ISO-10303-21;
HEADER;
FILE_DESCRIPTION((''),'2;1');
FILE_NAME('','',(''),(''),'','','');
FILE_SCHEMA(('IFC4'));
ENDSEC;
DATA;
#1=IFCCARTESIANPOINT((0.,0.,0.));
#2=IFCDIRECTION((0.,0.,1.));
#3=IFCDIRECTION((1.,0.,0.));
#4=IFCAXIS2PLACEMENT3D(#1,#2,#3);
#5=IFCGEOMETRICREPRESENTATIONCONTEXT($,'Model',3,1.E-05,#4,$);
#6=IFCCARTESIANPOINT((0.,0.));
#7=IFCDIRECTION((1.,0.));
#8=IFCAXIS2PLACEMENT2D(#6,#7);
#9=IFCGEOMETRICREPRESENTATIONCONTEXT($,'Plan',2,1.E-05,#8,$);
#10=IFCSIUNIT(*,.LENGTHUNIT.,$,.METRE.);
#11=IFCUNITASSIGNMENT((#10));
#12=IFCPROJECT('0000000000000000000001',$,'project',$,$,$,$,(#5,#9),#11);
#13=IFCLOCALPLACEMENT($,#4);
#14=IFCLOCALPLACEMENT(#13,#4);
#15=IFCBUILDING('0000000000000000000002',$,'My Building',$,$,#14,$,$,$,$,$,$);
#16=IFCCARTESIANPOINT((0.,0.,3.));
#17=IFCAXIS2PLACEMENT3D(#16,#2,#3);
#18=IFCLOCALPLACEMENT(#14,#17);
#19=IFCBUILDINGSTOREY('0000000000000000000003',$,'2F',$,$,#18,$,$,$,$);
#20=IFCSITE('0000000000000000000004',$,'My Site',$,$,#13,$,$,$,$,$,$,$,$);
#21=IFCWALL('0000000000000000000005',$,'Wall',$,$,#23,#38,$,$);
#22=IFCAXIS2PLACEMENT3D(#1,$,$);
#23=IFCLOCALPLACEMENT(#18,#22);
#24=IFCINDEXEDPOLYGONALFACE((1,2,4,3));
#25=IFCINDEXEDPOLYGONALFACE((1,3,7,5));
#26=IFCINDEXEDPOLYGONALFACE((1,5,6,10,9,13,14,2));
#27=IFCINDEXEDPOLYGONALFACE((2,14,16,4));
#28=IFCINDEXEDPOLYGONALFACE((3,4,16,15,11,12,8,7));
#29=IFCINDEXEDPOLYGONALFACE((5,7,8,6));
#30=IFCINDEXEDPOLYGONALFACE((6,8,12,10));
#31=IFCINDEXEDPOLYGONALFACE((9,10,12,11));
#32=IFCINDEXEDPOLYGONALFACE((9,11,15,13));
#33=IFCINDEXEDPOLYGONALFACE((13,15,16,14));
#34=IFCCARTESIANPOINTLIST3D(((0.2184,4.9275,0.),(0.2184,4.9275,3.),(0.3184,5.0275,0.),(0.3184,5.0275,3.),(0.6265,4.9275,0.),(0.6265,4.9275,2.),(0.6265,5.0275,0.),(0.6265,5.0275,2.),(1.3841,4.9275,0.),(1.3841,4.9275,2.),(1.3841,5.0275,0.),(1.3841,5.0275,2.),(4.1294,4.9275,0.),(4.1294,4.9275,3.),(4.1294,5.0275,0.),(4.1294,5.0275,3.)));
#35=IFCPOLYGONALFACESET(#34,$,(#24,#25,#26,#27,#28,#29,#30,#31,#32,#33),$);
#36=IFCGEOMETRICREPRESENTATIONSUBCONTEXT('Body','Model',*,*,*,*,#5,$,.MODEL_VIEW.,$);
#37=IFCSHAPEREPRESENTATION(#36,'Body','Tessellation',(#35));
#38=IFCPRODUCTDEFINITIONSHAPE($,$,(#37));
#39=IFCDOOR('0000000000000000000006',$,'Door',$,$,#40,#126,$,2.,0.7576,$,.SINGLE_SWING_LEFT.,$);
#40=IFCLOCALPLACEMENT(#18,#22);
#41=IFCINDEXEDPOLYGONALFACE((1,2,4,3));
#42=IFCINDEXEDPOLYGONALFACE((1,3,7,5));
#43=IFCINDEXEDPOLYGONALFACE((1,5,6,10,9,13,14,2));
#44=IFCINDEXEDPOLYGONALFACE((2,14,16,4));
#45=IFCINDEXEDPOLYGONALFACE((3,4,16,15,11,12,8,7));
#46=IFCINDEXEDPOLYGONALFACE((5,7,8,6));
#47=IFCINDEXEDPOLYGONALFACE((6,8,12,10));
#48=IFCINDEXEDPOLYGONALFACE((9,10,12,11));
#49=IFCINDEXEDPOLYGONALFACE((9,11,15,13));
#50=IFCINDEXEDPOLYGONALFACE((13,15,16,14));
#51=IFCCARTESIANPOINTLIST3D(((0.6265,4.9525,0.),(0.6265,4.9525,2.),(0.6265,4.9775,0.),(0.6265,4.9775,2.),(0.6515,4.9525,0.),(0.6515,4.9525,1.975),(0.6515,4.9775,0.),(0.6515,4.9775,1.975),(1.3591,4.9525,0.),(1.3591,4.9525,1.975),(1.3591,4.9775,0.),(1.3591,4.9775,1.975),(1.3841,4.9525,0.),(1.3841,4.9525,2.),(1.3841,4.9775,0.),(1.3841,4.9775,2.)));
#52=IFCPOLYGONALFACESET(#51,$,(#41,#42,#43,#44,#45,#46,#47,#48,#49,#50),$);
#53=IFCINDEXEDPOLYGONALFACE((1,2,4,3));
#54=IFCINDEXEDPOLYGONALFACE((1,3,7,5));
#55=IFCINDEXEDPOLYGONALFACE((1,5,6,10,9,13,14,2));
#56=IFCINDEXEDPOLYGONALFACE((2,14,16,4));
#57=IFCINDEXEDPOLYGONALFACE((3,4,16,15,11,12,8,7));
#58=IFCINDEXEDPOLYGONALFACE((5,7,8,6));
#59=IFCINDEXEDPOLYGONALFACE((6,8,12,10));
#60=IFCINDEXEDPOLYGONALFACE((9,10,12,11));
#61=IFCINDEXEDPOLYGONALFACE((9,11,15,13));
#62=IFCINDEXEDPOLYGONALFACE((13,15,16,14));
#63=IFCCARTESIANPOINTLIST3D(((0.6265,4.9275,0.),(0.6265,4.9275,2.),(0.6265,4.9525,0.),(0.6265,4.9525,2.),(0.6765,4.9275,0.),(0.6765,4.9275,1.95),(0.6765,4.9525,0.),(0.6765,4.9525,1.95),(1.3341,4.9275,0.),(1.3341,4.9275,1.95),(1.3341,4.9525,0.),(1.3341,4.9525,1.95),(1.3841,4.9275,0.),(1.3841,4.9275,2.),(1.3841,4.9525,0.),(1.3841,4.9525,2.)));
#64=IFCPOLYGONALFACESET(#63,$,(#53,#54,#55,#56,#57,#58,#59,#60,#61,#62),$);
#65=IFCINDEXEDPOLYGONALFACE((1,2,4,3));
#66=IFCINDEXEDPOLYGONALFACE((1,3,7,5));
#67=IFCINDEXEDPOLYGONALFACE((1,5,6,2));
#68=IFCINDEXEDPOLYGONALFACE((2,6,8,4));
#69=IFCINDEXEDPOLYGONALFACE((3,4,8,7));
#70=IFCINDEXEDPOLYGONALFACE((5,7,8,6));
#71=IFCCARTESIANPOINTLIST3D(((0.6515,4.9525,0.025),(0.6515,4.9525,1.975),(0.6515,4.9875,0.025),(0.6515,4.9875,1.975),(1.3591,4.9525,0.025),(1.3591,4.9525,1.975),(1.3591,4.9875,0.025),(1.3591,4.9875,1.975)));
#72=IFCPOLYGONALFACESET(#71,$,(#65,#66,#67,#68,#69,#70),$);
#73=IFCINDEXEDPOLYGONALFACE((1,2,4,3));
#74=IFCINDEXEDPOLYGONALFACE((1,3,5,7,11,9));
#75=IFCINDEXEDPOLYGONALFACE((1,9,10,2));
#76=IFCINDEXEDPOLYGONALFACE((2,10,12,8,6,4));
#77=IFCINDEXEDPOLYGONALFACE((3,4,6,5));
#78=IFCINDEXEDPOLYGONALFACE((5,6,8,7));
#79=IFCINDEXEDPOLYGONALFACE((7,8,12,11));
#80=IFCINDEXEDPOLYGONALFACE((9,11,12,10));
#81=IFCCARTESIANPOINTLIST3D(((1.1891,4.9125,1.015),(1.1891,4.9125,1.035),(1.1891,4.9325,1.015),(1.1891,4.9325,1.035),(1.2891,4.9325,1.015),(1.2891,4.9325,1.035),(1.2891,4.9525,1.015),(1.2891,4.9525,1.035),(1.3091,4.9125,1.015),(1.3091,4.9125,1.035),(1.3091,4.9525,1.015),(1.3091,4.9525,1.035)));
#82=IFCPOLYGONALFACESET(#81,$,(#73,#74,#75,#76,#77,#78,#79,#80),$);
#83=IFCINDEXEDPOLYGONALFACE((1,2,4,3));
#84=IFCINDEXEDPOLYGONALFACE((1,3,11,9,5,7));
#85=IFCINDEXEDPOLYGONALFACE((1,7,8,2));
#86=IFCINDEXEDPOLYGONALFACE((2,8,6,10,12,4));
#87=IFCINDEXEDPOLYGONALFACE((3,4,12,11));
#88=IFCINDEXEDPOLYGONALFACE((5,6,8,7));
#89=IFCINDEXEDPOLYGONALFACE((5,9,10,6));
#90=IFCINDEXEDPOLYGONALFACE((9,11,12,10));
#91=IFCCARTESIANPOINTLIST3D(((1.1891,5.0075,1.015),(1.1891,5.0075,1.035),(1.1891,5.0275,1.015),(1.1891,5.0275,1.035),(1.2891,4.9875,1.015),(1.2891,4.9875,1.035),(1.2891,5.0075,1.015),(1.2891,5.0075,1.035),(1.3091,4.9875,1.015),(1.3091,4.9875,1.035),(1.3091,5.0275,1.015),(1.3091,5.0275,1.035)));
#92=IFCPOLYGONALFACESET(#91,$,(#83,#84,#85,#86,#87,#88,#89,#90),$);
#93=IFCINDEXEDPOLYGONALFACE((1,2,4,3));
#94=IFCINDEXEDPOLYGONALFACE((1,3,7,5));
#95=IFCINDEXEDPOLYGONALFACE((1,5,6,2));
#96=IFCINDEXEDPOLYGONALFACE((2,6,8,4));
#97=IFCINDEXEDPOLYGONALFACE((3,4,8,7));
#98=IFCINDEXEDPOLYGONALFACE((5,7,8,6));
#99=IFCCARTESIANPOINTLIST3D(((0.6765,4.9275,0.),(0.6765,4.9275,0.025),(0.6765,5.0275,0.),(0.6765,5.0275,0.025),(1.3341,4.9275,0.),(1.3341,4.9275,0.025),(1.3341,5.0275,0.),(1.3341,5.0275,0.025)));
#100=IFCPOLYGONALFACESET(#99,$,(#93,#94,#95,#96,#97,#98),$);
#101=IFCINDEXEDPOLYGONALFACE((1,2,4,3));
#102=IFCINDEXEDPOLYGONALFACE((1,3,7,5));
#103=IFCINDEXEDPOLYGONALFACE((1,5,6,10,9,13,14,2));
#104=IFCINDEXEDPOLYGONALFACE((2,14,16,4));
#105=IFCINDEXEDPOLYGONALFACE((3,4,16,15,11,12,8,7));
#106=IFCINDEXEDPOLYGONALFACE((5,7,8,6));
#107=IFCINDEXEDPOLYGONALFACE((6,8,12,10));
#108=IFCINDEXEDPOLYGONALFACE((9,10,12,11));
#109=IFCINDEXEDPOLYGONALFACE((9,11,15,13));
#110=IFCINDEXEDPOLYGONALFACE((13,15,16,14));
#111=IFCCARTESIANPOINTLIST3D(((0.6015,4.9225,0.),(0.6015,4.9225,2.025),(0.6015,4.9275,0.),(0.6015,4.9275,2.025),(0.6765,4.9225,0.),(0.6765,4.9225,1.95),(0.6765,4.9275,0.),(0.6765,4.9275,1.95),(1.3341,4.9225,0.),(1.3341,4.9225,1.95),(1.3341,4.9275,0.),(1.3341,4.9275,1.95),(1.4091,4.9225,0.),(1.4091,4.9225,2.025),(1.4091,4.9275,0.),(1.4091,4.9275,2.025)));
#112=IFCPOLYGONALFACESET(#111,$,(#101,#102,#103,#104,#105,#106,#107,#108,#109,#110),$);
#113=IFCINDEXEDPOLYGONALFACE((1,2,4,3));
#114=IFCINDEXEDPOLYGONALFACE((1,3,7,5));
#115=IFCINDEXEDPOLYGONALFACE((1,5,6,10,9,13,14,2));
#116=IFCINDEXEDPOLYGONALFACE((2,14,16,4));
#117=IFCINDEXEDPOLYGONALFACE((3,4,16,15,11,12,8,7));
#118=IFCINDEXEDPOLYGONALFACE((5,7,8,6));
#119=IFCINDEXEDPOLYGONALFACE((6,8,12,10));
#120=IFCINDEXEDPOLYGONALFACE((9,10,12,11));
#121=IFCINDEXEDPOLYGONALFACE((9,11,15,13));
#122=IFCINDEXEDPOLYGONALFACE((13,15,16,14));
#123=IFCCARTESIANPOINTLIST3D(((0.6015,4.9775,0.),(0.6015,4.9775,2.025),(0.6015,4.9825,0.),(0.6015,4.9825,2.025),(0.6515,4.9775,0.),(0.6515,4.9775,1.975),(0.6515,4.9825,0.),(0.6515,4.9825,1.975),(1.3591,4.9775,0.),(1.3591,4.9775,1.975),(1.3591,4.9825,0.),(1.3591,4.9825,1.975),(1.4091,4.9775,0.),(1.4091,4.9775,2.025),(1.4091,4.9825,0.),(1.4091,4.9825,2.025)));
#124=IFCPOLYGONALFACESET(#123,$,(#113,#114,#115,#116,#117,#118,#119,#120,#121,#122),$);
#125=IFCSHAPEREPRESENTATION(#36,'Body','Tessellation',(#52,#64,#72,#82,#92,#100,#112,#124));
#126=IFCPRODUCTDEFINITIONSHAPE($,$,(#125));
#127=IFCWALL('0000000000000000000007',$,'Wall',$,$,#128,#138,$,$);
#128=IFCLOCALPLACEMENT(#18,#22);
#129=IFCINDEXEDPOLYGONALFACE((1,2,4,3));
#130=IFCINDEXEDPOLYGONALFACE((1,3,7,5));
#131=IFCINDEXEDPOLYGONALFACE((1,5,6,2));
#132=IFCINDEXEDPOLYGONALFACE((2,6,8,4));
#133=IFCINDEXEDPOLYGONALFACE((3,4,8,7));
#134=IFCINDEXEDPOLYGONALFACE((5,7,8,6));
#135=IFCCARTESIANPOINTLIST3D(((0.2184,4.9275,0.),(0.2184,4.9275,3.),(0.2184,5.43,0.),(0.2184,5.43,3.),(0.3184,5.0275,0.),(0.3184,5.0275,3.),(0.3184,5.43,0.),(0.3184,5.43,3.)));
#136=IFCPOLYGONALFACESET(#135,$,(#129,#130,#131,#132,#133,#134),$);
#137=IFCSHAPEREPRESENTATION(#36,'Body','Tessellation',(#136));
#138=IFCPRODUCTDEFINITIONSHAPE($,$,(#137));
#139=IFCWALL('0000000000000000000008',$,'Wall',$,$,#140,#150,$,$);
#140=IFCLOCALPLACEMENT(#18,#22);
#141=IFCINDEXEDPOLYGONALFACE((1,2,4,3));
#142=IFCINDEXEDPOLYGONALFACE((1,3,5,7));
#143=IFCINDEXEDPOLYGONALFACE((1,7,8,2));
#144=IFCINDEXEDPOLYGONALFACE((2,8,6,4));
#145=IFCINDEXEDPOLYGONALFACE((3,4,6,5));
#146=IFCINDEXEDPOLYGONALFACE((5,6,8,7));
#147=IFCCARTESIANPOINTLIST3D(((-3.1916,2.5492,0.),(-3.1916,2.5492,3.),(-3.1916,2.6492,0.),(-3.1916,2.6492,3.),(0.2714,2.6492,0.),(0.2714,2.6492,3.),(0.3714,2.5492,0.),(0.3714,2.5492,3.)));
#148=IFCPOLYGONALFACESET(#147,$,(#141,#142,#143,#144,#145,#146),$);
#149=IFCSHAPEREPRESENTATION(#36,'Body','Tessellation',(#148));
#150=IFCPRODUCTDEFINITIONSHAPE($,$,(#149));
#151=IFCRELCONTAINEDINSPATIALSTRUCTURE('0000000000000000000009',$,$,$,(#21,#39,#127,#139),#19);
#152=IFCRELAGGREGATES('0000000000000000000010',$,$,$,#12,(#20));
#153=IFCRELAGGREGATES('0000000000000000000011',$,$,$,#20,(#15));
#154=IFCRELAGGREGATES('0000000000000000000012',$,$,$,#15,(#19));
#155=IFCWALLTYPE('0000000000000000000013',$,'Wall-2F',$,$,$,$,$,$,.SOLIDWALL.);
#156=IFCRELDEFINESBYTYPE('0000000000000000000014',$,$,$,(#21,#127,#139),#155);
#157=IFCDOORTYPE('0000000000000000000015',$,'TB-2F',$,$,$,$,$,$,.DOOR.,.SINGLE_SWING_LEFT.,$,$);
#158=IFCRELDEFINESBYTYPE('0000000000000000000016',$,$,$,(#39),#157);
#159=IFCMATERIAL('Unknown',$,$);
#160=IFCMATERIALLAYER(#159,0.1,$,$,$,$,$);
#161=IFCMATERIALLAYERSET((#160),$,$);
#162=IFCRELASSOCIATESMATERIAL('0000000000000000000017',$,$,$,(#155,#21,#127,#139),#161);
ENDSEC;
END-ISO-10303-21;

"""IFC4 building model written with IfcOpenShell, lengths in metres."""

from ifc_helpers import new_model, entity, si_unit, frame, origin_with_axes, origin_2d_with_axis, place, context, subcontext, project, spatial, line, indexed_curve, outline, extrude, shape, source, transform, mapped, material, layer, layer_set, layer_usage, type_object, type_shapes, element, fill, save


model = new_model("IFC4")

# Units and contexts
model_context = context("Model", 3, precision=1e-05, world=origin_with_axes())
plan_context = context("Plan", 2, precision=1e-05, world=origin_2d_with_axis())
body_context_1 = subcontext(model_context, "Body", "Model", "MODEL_VIEW")
body_context_2 = subcontext(plan_context, "Body", "Plan", "PLAN_VIEW")
ifc_project = project(units=[si_unit("LENGTHUNIT", "METRE")], contexts=[model_context, plan_context])

# Site, building, storey
site_placement = place(None, origin_with_axes())
site = spatial("IfcSite", under=ifc_project, at=site_placement, Name="My Site")
building_placement = place(site_placement, origin_with_axes())
building = spatial("IfcBuilding", under=site, at=building_placement, Name="My Building")
storey_placement = place(building_placement, frame((0.0, 0.0, 3.0), z_axis=(0.0, 0.0, 1.0), x_axis=(1.0, 0.0, 0.0)))
storey = spatial("IfcBuildingStorey", under=building, at=storey_placement, Name="2F")

# Shared definitions
ifc_material = material(Name="Unknown")
ifc_layer = layer(ifc_material, 0.1)
ifc_layer_set = layer_set([ifc_layer])
wall_type = type_object("IfcWallType", Name="Wall-2F", PredefinedType="SOLIDWALL", material=ifc_layer_set)

# Wall, opening, door
ifc_layer_usage_1 = layer_usage(ifc_layer_set, "AXIS2", "POSITIVE", 0.0)
wall_1_placement = place(storey_placement, frame((4.2294, 5.0275, 0.0), z_axis=(0.0, 0.0, 1.0), x_axis=(-1.0, 0.0, 0.0)))
wall_1 = element("IfcWall", 1, at=wall_1_placement, inside=storey, type_object=wall_type, material=ifc_layer_usage_1, Name="Wall", context=body_context_1, shape_type="SweptSolid", body=[
    extrude(outline(indexed_curve([(0.1, 0.0), (0.1, 0.1), (4.0111, 0.1), (3.9111, 0.0)], segments=[line(1, 2, 3, 4, 1)])), origin_with_axes(), (0.0, 0.0, 1.0), 3.0),
])
shared_shape_1 = source(origin_with_axes(), body_context_1, "Body", "SweptSolid", [
    extrude(outline(indexed_curve([(0.0, 0.0), (0.7576, 0.0), (0.7576, 2.0), (0.0, 2.0)], segments=[line(1, 2, 3, 4, 1)])), frame((0.0, -0.6, 0.0), z_axis=(0.0, -1.0, 0.0), x_axis=(1.0, 0.0, 0.0)), (0.0, 0.0, -1.0), 1.2),
])
opening_1_placement = place(wall_1_placement, frame((3.6029, 0.1, 0.0), z_axis=(0.0, 0.0, 1.0), x_axis=(-1.0, 0.0, 0.0)))
opening_1 = element("IfcOpeningElement", 2, at=opening_1_placement, cuts=wall_1, PredefinedType="OPENING", context=body_context_1, shape_type="MappedRepresentation", body=[
    mapped(shared_shape_1, transform((0.0, 0.0, 0.0), x_axis=(1.0, 0.0, 0.0), y_axis=(0.0, 1.0, 0.0), z_axis=(0.0, 0.0, 1.0), scale=1.0)),
])
door_type_1 = type_object("IfcDoorType", Name="TB-2F", OperationType="SINGLE_SWING_LEFT", PredefinedType="DOOR")
shared_shape_2 = source(origin_with_axes(), body_context_1, "Body", "SweptSolid", [
    extrude(outline(indexed_curve([(0.0, 0.0), (0.0, 2.0), (0.7576, 2.0), (0.7576, 0.0), (0.7326, 0.0), (0.7326, 1.975), (0.025, 1.975), (0.025, 0.0)], segments=[line(1, 2, 3, 4, 5, 6, 7, 8, 1)])), frame((0.0, 0.025, 0.0), z_axis=(0.0, -1.0, 0.0), x_axis=(1.0, 0.0, 0.0)), (0.0, 0.0, -1.0), 0.025),
    extrude(outline(indexed_curve([(0.0, 0.0), (0.0, 2.0), (0.7576, 2.0), (0.7576, 0.0), (0.7076, 0.0), (0.7076, 1.95), (0.05, 1.95), (0.05, 0.0)], segments=[line(1, 2, 3, 4, 5, 6, 7, 8, 1)])), frame((0.0, 0.0, 0.0), z_axis=(0.0, -1.0, 0.0), x_axis=(1.0, 0.0, 0.0)), (0.0, 0.0, -1.0), 0.025),
    extrude(outline(indexed_curve([(0.0, 0.0), (0.7076, 0.0), (0.7076, 0.035), (0.0, 0.035)], segments=[line(1, 2, 3, 4, 1)])), frame((0.025, 0.025, 0.025), z_axis=(0.0, 0.0, 1.0), x_axis=(1.0, 0.0, 0.0)), (0.0, 0.0, 1.0), 1.95),
    extrude(outline(indexed_curve([(0.0, 0.0), (0.0, -0.04), (-0.12, -0.04), (-0.12, -0.02), (-0.02, -0.02), (-0.02, 0.0)], segments=[line(1, 2, 3, 4, 5, 6, 1)])), frame((0.6826, 0.025, 1.015), z_axis=(0.0, 0.0, 1.0), x_axis=(1.0, 0.0, 0.0)), (0.0, 0.0, 1.0), 0.02),
    extrude(outline(indexed_curve([(0.0, 0.0), (0.0, 0.04), (-0.12, 0.04), (-0.12, 0.02), (-0.02, 0.02), (-0.02, 0.0)], segments=[line(1, 2, 3, 4, 5, 6, 1)])), frame((0.6826, 0.06, 1.015), z_axis=(0.0, 0.0, 1.0), x_axis=(1.0, 0.0, 0.0)), (0.0, 0.0, 1.0), 0.02),
    extrude(outline(indexed_curve([(0.0, 0.0), (0.6576, 0.0), (0.6576, 0.1), (0.0, 0.1)], segments=[line(1, 2, 3, 4, 1)])), frame((0.05, 0.0, 0.0), z_axis=(0.0, 0.0, 1.0), x_axis=(1.0, 0.0, 0.0)), (0.0, 0.0, 1.0), 0.025),
    extrude(outline(indexed_curve([(0.0, 0.0), (0.0, 2.025), (0.8076, 2.025), (0.8076, 0.0), (0.7326, 0.0), (0.7326, 1.95), (0.075, 1.95), (0.075, 0.0)], segments=[line(1, 2, 3, 4, 5, 6, 7, 8, 1)])), frame((-0.025, -0.005, 0.0), z_axis=(0.0, -1.0, 0.0), x_axis=(1.0, 0.0, 0.0)), (0.0, 0.0, -1.0), 0.005),
    extrude(outline(indexed_curve([(0.0, 0.0), (0.0, 2.025), (0.8076, 2.025), (0.8076, 0.0), (0.7576, 0.0), (0.7576, 1.975), (0.05, 1.975), (0.05, 0.0)], segments=[line(1, 2, 3, 4, 5, 6, 7, 8, 1)])), frame((-0.025, 0.05, 0.0), z_axis=(0.0, -1.0, 0.0), x_axis=(1.0, 0.0, 0.0)), (0.0, 0.0, -1.0), 0.005),
])
shared_shape_3 = source(origin_with_axes(), body_context_2, "Body", "Curve2D", [
    entity("IfcIndexedPolyCurve", entity("IfcCartesianPointList2D", [[0.0, 0.0], [0.0, 0.05], [0.025, 0.05], [0.025, 0.025], [0.05, 0.025], [0.05, 0.0]]), [entity("IfcLineIndex", [1, 2, 3, 4, 5, 6, 1])]),
    entity("IfcIndexedPolyCurve", entity("IfcCartesianPointList2D", [[0.7576, 0.0], [0.7576, 0.05], [0.7326, 0.05], [0.7326, 0.025], [0.7076, 0.025], [0.7076, 0.0]]), [entity("IfcLineIndex", [1, 2, 3, 4, 5, 6, 1])]),
    entity("IfcTrimmedCurve", entity("IfcEllipse", entity("IfcAxis2Placement2D", entity("IfcCartesianPoint", [0.06, 0.05]), entity("IfcDirection", [1.0, 0.0])), 0.6726, 0.7076), [entity("IfcCartesianPoint", [0.7326, 0.05])], [entity("IfcCartesianPoint", [0.06, 0.7576])], True, "CARTESIAN"),
    entity("IfcIndexedPolyCurve", entity("IfcCartesianPointList2D", [[0.025, 0.05], [0.06, 0.05], [0.06, 0.7576], [0.025, 0.7576]]), [entity("IfcLineIndex", [1, 2, 3, 4, 1])]),
])
type_shapes(door_type_1, [shared_shape_2, shared_shape_3])
door_1_placement = place(opening_1_placement, frame((0.0, 0.0, 0.0), z_axis=(0.0, 0.0, 1.0), x_axis=(1.0, 0.0, 0.0)))
door_1 = element("IfcDoor", 3, at=door_1_placement, inside=storey, type_object=door_type_1, Name="Door", OperationType="SINGLE_SWING_LEFT", OverallHeight=2.0, OverallWidth=0.7576, shapes=[
    shape(body_context_1, "Body", "MappedRepresentation", [mapped(shared_shape_2, transform((0.0, 0.0, 0.0), x_axis=(1.0, 0.0, 0.0), y_axis=(0.0, 1.0, 0.0), z_axis=(0.0, 0.0, 1.0), scale=1.0))]),
    shape(body_context_2, "Body", "MappedRepresentation", [mapped(shared_shape_3, transform((0.0, 0.0, 0.0), x_axis=(1.0, 0.0, 0.0), y_axis=(0.0, 1.0, 0.0), z_axis=(0.0, 0.0, 1.0), scale=1.0))]),
])
fill(opening_1, door_1)

# Walls
ifc_layer_usage_2 = layer_usage(ifc_layer_set, "AXIS2", "NEGATIVE", 0.0)
wall_2_placement = place(storey_placement, frame((0.3184, 5.43, 0.0), z_axis=(0.0, 0.0, 1.0), x_axis=(0.0, -1.0, 0.0)))
element("IfcWall", 4, at=wall_2_placement, inside=storey, type_object=wall_type, material=ifc_layer_usage_2, Name="Wall", context=body_context_1, shape_type="SweptSolid", body=[
    extrude(outline(indexed_curve([(0.0, -0.1), (0.0, 0.0), (0.4025, 0.0), (0.5025, -0.1)], segments=[line(1, 2, 3, 4, 1)])), origin_with_axes(), (0.0, 0.0, 1.0), 3.0),
])
ifc_layer_usage_3 = layer_usage(ifc_layer_set, "AXIS2", "POSITIVE", 0.0)
wall_3_placement = place(storey_placement, frame((-3.1916, 2.5492, 0.0), z_axis=(0.0, 0.0, 1.0), x_axis=(1.0, 0.0, 0.0)))
element("IfcWall", 5, at=wall_3_placement, inside=storey, type_object=wall_type, material=ifc_layer_usage_3, Name="Wall", context=body_context_1, shape_type="SweptSolid", body=[
    extrude(outline(indexed_curve([(0.0, 0.0), (0.0, 0.1), (3.463, 0.1), (3.563, 0.0)], segments=[line(1, 2, 3, 4, 1)])), origin_with_axes(), (0.0, 0.0, 1.0), 3.0),
])

save(model, "model.ifc")
